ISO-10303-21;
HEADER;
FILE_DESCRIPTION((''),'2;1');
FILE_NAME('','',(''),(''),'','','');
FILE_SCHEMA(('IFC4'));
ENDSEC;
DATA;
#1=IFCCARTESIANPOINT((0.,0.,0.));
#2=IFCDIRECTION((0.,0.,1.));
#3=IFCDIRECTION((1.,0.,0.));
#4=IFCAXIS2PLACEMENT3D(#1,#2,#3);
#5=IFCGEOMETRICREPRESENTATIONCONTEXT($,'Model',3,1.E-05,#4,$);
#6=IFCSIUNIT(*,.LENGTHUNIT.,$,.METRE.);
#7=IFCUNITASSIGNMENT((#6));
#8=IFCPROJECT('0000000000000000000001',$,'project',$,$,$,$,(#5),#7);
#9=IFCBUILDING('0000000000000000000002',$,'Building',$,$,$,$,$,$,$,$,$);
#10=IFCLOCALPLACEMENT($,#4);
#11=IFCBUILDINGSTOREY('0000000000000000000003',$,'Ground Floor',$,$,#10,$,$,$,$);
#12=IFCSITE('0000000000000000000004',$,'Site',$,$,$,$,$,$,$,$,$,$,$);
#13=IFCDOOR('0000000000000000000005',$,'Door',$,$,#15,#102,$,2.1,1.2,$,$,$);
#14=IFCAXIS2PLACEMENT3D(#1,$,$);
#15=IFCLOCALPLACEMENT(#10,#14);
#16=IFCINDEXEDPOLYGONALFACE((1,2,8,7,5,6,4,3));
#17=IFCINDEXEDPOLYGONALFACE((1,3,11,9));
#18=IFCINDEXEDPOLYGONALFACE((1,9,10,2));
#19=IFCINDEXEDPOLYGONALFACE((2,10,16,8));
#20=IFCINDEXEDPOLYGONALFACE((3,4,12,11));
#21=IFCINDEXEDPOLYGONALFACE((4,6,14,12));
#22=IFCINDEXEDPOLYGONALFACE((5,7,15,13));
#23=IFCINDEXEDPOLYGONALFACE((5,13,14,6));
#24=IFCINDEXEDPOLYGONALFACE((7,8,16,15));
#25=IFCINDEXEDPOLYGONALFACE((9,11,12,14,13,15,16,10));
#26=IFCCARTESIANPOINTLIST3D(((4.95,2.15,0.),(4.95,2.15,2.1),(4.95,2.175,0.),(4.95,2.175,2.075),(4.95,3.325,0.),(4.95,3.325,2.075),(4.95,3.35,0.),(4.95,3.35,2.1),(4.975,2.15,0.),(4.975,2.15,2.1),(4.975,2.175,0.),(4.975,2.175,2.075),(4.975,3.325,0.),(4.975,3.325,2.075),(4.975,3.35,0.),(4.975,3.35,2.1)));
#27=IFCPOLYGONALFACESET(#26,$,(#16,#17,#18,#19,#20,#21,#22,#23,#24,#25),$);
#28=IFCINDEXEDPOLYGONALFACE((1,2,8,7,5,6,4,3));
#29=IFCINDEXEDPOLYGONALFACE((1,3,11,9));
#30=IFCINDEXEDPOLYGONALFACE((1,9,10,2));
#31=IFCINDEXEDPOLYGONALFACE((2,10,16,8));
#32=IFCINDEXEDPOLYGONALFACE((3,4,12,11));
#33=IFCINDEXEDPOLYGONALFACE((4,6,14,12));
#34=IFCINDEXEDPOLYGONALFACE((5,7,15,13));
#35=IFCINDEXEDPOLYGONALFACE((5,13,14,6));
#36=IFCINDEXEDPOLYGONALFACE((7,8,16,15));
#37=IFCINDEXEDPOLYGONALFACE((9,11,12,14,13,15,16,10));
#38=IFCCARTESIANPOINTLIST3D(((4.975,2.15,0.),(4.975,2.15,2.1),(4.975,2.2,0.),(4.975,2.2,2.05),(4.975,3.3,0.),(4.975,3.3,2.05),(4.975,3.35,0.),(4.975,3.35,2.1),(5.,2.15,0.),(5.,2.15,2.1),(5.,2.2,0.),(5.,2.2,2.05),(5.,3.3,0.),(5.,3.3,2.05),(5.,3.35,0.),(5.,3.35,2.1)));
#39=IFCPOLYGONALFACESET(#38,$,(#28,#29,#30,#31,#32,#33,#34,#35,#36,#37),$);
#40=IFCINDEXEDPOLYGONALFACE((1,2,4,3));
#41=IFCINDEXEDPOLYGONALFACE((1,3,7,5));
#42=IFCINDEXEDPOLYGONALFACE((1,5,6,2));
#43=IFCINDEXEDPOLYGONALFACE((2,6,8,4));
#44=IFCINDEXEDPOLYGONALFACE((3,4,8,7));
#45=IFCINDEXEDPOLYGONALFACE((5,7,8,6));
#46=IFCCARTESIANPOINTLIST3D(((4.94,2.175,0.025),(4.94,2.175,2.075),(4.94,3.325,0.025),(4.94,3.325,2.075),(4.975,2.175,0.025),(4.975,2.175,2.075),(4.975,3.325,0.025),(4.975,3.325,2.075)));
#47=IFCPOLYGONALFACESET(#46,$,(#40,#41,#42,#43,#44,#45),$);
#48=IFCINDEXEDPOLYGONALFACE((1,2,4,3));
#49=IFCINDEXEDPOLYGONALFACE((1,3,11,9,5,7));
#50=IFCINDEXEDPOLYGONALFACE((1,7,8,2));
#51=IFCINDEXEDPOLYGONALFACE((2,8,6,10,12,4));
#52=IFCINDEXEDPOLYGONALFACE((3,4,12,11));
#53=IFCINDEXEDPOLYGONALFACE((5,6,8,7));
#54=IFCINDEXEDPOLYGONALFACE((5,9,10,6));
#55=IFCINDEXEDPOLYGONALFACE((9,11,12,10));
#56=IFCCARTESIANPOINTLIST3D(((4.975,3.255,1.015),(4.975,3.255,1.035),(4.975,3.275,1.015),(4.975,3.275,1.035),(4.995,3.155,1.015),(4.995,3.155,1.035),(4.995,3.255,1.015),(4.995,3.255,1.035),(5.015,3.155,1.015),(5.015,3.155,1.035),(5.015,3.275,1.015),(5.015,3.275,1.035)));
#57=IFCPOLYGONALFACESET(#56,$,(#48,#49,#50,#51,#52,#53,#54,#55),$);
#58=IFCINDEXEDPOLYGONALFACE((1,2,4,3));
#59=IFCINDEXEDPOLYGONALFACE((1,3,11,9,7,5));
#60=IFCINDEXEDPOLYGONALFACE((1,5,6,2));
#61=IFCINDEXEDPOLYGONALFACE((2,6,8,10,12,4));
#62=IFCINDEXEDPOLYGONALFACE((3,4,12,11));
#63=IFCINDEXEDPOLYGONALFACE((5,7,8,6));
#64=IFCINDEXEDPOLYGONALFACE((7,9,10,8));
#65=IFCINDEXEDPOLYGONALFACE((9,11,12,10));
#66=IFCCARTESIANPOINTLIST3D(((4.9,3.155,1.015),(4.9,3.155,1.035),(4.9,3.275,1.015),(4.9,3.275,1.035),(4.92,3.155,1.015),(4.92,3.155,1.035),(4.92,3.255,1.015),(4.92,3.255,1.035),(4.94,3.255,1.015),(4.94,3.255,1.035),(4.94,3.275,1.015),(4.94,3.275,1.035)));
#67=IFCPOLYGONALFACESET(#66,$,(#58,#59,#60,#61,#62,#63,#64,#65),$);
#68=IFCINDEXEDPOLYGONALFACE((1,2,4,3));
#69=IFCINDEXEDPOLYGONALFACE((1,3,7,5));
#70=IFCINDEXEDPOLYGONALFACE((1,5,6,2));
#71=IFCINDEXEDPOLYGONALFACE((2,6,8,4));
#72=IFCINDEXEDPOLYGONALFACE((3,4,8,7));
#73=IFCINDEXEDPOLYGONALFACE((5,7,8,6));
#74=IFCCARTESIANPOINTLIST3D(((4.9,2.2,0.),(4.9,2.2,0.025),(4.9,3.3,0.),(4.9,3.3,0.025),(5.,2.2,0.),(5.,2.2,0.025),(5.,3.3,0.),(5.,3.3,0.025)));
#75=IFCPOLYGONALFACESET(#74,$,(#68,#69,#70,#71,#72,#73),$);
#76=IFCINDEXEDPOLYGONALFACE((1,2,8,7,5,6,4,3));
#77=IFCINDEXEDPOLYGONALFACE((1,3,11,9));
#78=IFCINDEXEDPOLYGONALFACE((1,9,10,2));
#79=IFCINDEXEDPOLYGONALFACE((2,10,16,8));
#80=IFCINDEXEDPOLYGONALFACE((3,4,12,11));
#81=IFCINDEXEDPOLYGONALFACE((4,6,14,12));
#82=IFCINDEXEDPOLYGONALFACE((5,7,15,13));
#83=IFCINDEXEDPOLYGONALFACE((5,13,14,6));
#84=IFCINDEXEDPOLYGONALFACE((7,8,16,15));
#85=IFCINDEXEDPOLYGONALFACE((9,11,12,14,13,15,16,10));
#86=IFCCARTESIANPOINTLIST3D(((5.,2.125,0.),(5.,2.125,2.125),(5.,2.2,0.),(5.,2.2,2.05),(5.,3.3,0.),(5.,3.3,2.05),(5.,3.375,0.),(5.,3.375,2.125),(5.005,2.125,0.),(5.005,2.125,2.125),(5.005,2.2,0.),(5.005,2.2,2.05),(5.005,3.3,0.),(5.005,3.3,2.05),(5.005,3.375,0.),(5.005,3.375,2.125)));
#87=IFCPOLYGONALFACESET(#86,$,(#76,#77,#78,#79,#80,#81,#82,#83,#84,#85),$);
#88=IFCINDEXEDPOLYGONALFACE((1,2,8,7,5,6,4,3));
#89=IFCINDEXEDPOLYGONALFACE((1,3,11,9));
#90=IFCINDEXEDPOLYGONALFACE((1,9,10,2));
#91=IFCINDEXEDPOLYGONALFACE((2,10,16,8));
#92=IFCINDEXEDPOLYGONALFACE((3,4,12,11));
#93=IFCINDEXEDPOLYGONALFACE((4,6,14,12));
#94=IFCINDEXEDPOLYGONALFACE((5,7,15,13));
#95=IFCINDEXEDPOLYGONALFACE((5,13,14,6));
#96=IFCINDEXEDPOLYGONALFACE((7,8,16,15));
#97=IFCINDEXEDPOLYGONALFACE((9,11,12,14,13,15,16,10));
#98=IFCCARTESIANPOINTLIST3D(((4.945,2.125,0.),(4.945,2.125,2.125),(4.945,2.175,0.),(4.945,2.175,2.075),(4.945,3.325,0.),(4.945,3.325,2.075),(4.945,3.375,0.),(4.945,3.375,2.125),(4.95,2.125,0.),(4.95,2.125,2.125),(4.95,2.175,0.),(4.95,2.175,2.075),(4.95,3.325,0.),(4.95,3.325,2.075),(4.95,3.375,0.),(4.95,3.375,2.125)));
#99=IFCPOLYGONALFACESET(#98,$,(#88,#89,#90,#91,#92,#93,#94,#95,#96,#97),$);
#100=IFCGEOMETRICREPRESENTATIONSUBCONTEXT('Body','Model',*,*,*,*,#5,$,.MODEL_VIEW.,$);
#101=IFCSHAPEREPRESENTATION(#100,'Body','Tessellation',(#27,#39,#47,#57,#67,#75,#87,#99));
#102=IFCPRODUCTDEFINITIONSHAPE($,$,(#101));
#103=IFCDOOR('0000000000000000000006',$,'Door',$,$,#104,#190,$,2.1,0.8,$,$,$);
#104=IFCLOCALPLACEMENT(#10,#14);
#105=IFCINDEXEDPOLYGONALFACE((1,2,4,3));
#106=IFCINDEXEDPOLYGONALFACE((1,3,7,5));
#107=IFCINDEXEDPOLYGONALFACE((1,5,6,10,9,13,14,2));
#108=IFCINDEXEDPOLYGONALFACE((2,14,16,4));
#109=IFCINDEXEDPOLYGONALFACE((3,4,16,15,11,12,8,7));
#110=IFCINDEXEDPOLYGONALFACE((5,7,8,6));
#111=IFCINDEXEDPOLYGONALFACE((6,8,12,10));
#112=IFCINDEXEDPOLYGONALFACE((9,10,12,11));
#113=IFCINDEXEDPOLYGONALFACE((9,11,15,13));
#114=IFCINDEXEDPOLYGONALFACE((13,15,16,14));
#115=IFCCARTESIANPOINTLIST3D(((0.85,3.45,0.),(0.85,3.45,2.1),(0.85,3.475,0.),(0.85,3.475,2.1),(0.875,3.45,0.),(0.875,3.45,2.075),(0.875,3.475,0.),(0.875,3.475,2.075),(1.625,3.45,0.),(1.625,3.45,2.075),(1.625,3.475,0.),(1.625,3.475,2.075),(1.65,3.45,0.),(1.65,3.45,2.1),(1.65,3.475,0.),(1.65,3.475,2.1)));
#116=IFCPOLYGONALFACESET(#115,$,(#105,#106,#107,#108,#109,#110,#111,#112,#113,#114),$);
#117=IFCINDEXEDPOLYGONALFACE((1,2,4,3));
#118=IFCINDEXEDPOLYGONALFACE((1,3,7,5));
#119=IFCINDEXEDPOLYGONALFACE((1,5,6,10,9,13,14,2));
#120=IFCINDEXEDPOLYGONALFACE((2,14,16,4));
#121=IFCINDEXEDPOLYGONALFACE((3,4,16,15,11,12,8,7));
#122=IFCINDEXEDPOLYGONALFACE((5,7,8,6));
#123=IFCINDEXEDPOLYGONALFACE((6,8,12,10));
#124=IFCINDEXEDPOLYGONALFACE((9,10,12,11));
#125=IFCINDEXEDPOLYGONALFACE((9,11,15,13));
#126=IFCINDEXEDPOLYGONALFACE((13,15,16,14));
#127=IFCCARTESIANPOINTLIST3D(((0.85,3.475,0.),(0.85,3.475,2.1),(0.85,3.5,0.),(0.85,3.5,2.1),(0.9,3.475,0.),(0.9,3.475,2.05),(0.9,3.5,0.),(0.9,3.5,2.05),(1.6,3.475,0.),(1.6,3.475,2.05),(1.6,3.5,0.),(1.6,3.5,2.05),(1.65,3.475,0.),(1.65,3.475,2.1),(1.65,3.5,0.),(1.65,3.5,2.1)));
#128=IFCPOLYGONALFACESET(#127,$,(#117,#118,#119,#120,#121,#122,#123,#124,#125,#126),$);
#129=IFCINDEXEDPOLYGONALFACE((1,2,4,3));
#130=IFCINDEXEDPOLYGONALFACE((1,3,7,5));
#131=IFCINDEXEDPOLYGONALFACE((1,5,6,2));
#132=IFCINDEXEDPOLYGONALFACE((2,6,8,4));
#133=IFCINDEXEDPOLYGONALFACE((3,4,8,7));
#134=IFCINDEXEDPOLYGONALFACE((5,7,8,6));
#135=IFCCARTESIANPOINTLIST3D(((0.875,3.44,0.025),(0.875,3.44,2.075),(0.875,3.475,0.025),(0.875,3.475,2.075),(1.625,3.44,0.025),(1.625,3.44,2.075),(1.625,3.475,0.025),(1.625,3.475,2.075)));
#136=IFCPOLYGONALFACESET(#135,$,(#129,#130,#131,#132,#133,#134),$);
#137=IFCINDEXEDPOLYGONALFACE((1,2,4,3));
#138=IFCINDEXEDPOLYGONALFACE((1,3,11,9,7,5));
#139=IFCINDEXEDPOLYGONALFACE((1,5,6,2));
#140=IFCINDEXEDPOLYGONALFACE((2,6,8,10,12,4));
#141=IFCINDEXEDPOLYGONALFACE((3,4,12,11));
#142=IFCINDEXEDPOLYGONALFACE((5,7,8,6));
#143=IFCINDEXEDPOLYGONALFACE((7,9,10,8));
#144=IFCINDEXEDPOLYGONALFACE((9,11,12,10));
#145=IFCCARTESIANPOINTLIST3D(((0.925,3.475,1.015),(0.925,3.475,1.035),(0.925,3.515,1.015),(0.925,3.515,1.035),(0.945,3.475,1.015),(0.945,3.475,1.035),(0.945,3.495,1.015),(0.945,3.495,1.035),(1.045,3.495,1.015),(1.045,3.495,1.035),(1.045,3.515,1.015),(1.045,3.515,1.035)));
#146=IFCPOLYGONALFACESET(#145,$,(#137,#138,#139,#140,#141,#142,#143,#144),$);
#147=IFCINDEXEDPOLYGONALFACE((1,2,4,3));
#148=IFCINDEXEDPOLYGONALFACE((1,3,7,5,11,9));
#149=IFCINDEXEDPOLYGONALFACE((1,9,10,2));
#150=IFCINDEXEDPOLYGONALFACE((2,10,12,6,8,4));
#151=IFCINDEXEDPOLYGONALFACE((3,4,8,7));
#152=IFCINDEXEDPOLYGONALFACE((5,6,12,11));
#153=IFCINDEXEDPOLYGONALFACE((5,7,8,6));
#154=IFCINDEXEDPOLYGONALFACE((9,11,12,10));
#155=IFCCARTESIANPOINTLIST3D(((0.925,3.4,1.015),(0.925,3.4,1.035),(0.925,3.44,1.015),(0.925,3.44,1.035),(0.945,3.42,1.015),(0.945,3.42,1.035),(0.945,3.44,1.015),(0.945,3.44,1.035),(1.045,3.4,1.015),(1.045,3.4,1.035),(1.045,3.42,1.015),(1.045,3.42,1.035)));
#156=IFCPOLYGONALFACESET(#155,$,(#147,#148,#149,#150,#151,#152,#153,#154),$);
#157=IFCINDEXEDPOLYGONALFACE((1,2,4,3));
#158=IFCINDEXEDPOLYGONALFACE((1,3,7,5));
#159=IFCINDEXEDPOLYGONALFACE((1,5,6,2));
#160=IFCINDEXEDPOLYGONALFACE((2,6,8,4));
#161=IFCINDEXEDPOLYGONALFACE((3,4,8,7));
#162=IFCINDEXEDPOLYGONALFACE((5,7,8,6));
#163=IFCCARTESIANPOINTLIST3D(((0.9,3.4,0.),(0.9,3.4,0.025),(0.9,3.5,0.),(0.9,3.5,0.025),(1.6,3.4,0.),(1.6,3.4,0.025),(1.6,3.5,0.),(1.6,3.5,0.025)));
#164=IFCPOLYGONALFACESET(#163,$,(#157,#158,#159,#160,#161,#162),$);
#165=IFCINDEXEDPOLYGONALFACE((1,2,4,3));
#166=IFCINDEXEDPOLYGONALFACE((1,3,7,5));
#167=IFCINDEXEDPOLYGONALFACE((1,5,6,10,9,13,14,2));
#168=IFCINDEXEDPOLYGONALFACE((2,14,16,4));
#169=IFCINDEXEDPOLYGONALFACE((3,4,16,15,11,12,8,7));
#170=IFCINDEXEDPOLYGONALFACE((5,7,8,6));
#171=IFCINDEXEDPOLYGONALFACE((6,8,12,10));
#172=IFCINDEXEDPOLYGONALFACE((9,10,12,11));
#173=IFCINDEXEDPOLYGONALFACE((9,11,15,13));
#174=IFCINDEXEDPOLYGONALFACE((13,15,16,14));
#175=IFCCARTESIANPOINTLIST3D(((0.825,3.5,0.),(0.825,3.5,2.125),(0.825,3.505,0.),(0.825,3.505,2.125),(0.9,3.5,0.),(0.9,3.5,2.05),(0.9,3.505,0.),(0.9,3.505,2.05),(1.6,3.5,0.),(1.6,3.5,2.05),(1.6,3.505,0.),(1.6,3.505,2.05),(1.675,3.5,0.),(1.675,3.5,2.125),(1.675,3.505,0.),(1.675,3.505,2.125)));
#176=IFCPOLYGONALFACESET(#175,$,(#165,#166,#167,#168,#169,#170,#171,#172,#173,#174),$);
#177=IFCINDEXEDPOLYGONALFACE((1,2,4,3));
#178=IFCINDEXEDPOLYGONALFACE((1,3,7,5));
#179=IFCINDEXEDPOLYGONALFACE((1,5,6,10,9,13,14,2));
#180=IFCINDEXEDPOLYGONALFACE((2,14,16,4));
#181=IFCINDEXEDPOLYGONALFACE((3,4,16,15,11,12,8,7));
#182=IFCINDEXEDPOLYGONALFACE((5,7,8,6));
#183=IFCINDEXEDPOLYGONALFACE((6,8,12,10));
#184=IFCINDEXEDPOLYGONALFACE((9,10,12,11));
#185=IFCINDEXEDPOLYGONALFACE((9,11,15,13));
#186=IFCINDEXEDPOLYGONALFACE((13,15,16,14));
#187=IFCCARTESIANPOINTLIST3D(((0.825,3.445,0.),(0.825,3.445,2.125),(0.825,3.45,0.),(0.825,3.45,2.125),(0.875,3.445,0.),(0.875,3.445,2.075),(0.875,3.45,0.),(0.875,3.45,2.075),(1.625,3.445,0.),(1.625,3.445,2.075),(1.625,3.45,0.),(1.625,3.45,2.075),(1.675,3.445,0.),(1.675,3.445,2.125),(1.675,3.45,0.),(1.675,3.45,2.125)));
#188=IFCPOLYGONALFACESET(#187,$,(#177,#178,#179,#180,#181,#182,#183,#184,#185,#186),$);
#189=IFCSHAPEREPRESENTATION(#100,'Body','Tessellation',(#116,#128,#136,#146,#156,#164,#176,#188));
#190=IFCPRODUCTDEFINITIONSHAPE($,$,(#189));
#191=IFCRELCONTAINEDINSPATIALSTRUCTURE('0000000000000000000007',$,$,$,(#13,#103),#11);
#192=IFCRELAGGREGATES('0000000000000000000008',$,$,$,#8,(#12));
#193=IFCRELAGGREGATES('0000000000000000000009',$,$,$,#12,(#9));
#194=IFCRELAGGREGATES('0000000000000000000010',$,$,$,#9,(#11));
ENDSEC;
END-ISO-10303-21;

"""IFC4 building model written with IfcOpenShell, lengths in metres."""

from ifc_helpers import new_model, si_unit, frame, origin_with_axes, place, context, subcontext, project, spatial, line, indexed_curve, outline, extrude, element, save


model = new_model("IFC4")

# Units and contexts
model_context = context("Model", 3, precision=1e-05, world=origin_with_axes())
body_context = subcontext(model_context, "Body", "Model", "MODEL_VIEW")
ifc_project = project(units=[si_unit("LENGTHUNIT", "METRE")], contexts=[model_context])

# Site, building, storey
site = spatial("IfcSite", under=ifc_project, Name="Site")
building = spatial("IfcBuilding", under=site, Name="Building")
storey_placement = place(None, origin_with_axes())
storey = spatial("IfcBuildingStorey", under=building, at=storey_placement, Name="Ground Floor")

# Doors
door_1_placement = place(storey_placement, frame((5.0, 2.15, 0.0), z_axis=(0.0, 0.0, 1.0), x_axis=(0.0, 1.0, 0.0)))
element("IfcDoor", 1, at=door_1_placement, inside=storey, Name="Door", OverallHeight=2.1, OverallWidth=1.2, context=body_context, shape_type="SweptSolid", body=[
    extrude(outline(indexed_curve([(0.0, 0.0), (0.0, 2.1), (1.2, 2.1), (1.2, 0.0), (1.175, 0.0), (1.175, 2.075), (0.025, 2.075), (0.025, 0.0)], segments=[line(1, 2, 3, 4, 5, 6, 7, 8, 1)])), frame((0.0, 0.025, 0.0), z_axis=(0.0, -1.0, 0.0), x_axis=(1.0, 0.0, 0.0)), (0.0, 0.0, -1.0), 0.025),
    extrude(outline(indexed_curve([(0.0, 0.0), (0.0, 2.1), (1.2, 2.1), (1.2, 0.0), (1.15, 0.0), (1.15, 2.05), (0.05, 2.05), (0.05, 0.0)], segments=[line(1, 2, 3, 4, 5, 6, 7, 8, 1)])), frame((0.0, 0.0, 0.0), z_axis=(0.0, -1.0, 0.0), x_axis=(1.0, 0.0, 0.0)), (0.0, 0.0, -1.0), 0.025),
    extrude(outline(indexed_curve([(0.0, 0.0), (1.15, 0.0), (1.15, 0.035), (0.0, 0.035)], segments=[line(1, 2, 3, 4, 1)])), frame((0.025, 0.025, 0.025), z_axis=(0.0, 0.0, 1.0), x_axis=(1.0, 0.0, 0.0)), (0.0, 0.0, 1.0), 2.05),
    extrude(outline(indexed_curve([(0.0, 0.0), (0.0, -0.04), (-0.12, -0.04), (-0.12, -0.02), (-0.02, -0.02), (-0.02, 0.0)], segments=[line(1, 2, 3, 4, 5, 6, 1)])), frame((1.125, 0.025, 1.015), z_axis=(0.0, 0.0, 1.0), x_axis=(1.0, 0.0, 0.0)), (0.0, 0.0, 1.0), 0.02),
    extrude(outline(indexed_curve([(0.0, 0.0), (0.0, 0.04), (-0.12, 0.04), (-0.12, 0.02), (-0.02, 0.02), (-0.02, 0.0)], segments=[line(1, 2, 3, 4, 5, 6, 1)])), frame((1.125, 0.06, 1.015), z_axis=(0.0, 0.0, 1.0), x_axis=(1.0, 0.0, 0.0)), (0.0, 0.0, 1.0), 0.02),
    extrude(outline(indexed_curve([(0.0, 0.0), (1.1, 0.0), (1.1, 0.1), (0.0, 0.1)], segments=[line(1, 2, 3, 4, 1)])), frame((0.05, 0.0, 0.0), z_axis=(0.0, 0.0, 1.0), x_axis=(1.0, 0.0, 0.0)), (0.0, 0.0, 1.0), 0.025),
    extrude(outline(indexed_curve([(0.0, 0.0), (0.0, 2.125), (1.25, 2.125), (1.25, 0.0), (1.175, 0.0), (1.175, 2.05), (0.075, 2.05), (0.075, 0.0)], segments=[line(1, 2, 3, 4, 5, 6, 7, 8, 1)])), frame((-0.025, -0.005, 0.0), z_axis=(0.0, -1.0, 0.0), x_axis=(1.0, 0.0, 0.0)), (0.0, 0.0, -1.0), 0.005),
    extrude(outline(indexed_curve([(0.0, 0.0), (0.0, 2.125), (1.25, 2.125), (1.25, 0.0), (1.2, 0.0), (1.2, 2.075), (0.05, 2.075), (0.05, 0.0)], segments=[line(1, 2, 3, 4, 5, 6, 7, 8, 1)])), frame((-0.025, 0.05, 0.0), z_axis=(0.0, -1.0, 0.0), x_axis=(1.0, 0.0, 0.0)), (0.0, 0.0, -1.0), 0.005),
])
door_2_placement = place(storey_placement, frame((1.65, 3.5, 0.0), z_axis=(0.0, 0.0, 1.0), x_axis=(-1.0, 0.0, 0.0)))
element("IfcDoor", 2, at=door_2_placement, inside=storey, Name="Door", OverallHeight=2.1, OverallWidth=0.8, context=body_context, shape_type="SweptSolid", body=[
    extrude(outline(indexed_curve([(0.0, 0.0), (0.0, 2.1), (0.8, 2.1), (0.8, 0.0), (0.775, 0.0), (0.775, 2.075), (0.025, 2.075), (0.025, 0.0)], segments=[line(1, 2, 3, 4, 5, 6, 7, 8, 1)])), frame((0.0, 0.025, 0.0), z_axis=(0.0, -1.0, 0.0), x_axis=(1.0, 0.0, 0.0)), (0.0, 0.0, -1.0), 0.025),
    extrude(outline(indexed_curve([(0.0, 0.0), (0.0, 2.1), (0.8, 2.1), (0.8, 0.0), (0.75, 0.0), (0.75, 2.05), (0.05, 2.05), (0.05, 0.0)], segments=[line(1, 2, 3, 4, 5, 6, 7, 8, 1)])), frame((0.0, 0.0, 0.0), z_axis=(0.0, -1.0, 0.0), x_axis=(1.0, 0.0, 0.0)), (0.0, 0.0, -1.0), 0.025),
    extrude(outline(indexed_curve([(0.0, 0.0), (0.75, 0.0), (0.75, 0.035), (0.0, 0.035)], segments=[line(1, 2, 3, 4, 1)])), frame((0.025, 0.025, 0.025), z_axis=(0.0, 0.0, 1.0), x_axis=(1.0, 0.0, 0.0)), (0.0, 0.0, 1.0), 2.05),
    extrude(outline(indexed_curve([(0.0, 0.0), (0.0, -0.04), (-0.12, -0.04), (-0.12, -0.02), (-0.02, -0.02), (-0.02, 0.0)], segments=[line(1, 2, 3, 4, 5, 6, 1)])), frame((0.725, 0.025, 1.015), z_axis=(0.0, 0.0, 1.0), x_axis=(1.0, 0.0, 0.0)), (0.0, 0.0, 1.0), 0.02),
    extrude(outline(indexed_curve([(0.0, 0.0), (0.0, 0.04), (-0.12, 0.04), (-0.12, 0.02), (-0.02, 0.02), (-0.02, 0.0)], segments=[line(1, 2, 3, 4, 5, 6, 1)])), frame((0.725, 0.06, 1.015), z_axis=(0.0, 0.0, 1.0), x_axis=(1.0, 0.0, 0.0)), (0.0, 0.0, 1.0), 0.02),
    extrude(outline(indexed_curve([(0.0, 0.0), (0.7, 0.0), (0.7, 0.1), (0.0, 0.1)], segments=[line(1, 2, 3, 4, 1)])), frame((0.05, 0.0, 0.0), z_axis=(0.0, 0.0, 1.0), x_axis=(1.0, 0.0, 0.0)), (0.0, 0.0, 1.0), 0.025),
    extrude(outline(indexed_curve([(0.0, 0.0), (0.0, 2.125), (0.85, 2.125), (0.85, 0.0), (0.775, 0.0), (0.775, 2.05), (0.075, 2.05), (0.075, 0.0)], segments=[line(1, 2, 3, 4, 5, 6, 7, 8, 1)])), frame((-0.025, -0.005, 0.0), z_axis=(0.0, -1.0, 0.0), x_axis=(1.0, 0.0, 0.0)), (0.0, 0.0, -1.0), 0.005),
    extrude(outline(indexed_curve([(0.0, 0.0), (0.0, 2.125), (0.85, 2.125), (0.85, 0.0), (0.8, 0.0), (0.8, 2.075), (0.05, 2.075), (0.05, 0.0)], segments=[line(1, 2, 3, 4, 5, 6, 7, 8, 1)])), frame((-0.025, 0.05, 0.0), z_axis=(0.0, -1.0, 0.0), x_axis=(1.0, 0.0, 0.0)), (0.0, 0.0, -1.0), 0.005),
])

save(model, "model.ifc")
